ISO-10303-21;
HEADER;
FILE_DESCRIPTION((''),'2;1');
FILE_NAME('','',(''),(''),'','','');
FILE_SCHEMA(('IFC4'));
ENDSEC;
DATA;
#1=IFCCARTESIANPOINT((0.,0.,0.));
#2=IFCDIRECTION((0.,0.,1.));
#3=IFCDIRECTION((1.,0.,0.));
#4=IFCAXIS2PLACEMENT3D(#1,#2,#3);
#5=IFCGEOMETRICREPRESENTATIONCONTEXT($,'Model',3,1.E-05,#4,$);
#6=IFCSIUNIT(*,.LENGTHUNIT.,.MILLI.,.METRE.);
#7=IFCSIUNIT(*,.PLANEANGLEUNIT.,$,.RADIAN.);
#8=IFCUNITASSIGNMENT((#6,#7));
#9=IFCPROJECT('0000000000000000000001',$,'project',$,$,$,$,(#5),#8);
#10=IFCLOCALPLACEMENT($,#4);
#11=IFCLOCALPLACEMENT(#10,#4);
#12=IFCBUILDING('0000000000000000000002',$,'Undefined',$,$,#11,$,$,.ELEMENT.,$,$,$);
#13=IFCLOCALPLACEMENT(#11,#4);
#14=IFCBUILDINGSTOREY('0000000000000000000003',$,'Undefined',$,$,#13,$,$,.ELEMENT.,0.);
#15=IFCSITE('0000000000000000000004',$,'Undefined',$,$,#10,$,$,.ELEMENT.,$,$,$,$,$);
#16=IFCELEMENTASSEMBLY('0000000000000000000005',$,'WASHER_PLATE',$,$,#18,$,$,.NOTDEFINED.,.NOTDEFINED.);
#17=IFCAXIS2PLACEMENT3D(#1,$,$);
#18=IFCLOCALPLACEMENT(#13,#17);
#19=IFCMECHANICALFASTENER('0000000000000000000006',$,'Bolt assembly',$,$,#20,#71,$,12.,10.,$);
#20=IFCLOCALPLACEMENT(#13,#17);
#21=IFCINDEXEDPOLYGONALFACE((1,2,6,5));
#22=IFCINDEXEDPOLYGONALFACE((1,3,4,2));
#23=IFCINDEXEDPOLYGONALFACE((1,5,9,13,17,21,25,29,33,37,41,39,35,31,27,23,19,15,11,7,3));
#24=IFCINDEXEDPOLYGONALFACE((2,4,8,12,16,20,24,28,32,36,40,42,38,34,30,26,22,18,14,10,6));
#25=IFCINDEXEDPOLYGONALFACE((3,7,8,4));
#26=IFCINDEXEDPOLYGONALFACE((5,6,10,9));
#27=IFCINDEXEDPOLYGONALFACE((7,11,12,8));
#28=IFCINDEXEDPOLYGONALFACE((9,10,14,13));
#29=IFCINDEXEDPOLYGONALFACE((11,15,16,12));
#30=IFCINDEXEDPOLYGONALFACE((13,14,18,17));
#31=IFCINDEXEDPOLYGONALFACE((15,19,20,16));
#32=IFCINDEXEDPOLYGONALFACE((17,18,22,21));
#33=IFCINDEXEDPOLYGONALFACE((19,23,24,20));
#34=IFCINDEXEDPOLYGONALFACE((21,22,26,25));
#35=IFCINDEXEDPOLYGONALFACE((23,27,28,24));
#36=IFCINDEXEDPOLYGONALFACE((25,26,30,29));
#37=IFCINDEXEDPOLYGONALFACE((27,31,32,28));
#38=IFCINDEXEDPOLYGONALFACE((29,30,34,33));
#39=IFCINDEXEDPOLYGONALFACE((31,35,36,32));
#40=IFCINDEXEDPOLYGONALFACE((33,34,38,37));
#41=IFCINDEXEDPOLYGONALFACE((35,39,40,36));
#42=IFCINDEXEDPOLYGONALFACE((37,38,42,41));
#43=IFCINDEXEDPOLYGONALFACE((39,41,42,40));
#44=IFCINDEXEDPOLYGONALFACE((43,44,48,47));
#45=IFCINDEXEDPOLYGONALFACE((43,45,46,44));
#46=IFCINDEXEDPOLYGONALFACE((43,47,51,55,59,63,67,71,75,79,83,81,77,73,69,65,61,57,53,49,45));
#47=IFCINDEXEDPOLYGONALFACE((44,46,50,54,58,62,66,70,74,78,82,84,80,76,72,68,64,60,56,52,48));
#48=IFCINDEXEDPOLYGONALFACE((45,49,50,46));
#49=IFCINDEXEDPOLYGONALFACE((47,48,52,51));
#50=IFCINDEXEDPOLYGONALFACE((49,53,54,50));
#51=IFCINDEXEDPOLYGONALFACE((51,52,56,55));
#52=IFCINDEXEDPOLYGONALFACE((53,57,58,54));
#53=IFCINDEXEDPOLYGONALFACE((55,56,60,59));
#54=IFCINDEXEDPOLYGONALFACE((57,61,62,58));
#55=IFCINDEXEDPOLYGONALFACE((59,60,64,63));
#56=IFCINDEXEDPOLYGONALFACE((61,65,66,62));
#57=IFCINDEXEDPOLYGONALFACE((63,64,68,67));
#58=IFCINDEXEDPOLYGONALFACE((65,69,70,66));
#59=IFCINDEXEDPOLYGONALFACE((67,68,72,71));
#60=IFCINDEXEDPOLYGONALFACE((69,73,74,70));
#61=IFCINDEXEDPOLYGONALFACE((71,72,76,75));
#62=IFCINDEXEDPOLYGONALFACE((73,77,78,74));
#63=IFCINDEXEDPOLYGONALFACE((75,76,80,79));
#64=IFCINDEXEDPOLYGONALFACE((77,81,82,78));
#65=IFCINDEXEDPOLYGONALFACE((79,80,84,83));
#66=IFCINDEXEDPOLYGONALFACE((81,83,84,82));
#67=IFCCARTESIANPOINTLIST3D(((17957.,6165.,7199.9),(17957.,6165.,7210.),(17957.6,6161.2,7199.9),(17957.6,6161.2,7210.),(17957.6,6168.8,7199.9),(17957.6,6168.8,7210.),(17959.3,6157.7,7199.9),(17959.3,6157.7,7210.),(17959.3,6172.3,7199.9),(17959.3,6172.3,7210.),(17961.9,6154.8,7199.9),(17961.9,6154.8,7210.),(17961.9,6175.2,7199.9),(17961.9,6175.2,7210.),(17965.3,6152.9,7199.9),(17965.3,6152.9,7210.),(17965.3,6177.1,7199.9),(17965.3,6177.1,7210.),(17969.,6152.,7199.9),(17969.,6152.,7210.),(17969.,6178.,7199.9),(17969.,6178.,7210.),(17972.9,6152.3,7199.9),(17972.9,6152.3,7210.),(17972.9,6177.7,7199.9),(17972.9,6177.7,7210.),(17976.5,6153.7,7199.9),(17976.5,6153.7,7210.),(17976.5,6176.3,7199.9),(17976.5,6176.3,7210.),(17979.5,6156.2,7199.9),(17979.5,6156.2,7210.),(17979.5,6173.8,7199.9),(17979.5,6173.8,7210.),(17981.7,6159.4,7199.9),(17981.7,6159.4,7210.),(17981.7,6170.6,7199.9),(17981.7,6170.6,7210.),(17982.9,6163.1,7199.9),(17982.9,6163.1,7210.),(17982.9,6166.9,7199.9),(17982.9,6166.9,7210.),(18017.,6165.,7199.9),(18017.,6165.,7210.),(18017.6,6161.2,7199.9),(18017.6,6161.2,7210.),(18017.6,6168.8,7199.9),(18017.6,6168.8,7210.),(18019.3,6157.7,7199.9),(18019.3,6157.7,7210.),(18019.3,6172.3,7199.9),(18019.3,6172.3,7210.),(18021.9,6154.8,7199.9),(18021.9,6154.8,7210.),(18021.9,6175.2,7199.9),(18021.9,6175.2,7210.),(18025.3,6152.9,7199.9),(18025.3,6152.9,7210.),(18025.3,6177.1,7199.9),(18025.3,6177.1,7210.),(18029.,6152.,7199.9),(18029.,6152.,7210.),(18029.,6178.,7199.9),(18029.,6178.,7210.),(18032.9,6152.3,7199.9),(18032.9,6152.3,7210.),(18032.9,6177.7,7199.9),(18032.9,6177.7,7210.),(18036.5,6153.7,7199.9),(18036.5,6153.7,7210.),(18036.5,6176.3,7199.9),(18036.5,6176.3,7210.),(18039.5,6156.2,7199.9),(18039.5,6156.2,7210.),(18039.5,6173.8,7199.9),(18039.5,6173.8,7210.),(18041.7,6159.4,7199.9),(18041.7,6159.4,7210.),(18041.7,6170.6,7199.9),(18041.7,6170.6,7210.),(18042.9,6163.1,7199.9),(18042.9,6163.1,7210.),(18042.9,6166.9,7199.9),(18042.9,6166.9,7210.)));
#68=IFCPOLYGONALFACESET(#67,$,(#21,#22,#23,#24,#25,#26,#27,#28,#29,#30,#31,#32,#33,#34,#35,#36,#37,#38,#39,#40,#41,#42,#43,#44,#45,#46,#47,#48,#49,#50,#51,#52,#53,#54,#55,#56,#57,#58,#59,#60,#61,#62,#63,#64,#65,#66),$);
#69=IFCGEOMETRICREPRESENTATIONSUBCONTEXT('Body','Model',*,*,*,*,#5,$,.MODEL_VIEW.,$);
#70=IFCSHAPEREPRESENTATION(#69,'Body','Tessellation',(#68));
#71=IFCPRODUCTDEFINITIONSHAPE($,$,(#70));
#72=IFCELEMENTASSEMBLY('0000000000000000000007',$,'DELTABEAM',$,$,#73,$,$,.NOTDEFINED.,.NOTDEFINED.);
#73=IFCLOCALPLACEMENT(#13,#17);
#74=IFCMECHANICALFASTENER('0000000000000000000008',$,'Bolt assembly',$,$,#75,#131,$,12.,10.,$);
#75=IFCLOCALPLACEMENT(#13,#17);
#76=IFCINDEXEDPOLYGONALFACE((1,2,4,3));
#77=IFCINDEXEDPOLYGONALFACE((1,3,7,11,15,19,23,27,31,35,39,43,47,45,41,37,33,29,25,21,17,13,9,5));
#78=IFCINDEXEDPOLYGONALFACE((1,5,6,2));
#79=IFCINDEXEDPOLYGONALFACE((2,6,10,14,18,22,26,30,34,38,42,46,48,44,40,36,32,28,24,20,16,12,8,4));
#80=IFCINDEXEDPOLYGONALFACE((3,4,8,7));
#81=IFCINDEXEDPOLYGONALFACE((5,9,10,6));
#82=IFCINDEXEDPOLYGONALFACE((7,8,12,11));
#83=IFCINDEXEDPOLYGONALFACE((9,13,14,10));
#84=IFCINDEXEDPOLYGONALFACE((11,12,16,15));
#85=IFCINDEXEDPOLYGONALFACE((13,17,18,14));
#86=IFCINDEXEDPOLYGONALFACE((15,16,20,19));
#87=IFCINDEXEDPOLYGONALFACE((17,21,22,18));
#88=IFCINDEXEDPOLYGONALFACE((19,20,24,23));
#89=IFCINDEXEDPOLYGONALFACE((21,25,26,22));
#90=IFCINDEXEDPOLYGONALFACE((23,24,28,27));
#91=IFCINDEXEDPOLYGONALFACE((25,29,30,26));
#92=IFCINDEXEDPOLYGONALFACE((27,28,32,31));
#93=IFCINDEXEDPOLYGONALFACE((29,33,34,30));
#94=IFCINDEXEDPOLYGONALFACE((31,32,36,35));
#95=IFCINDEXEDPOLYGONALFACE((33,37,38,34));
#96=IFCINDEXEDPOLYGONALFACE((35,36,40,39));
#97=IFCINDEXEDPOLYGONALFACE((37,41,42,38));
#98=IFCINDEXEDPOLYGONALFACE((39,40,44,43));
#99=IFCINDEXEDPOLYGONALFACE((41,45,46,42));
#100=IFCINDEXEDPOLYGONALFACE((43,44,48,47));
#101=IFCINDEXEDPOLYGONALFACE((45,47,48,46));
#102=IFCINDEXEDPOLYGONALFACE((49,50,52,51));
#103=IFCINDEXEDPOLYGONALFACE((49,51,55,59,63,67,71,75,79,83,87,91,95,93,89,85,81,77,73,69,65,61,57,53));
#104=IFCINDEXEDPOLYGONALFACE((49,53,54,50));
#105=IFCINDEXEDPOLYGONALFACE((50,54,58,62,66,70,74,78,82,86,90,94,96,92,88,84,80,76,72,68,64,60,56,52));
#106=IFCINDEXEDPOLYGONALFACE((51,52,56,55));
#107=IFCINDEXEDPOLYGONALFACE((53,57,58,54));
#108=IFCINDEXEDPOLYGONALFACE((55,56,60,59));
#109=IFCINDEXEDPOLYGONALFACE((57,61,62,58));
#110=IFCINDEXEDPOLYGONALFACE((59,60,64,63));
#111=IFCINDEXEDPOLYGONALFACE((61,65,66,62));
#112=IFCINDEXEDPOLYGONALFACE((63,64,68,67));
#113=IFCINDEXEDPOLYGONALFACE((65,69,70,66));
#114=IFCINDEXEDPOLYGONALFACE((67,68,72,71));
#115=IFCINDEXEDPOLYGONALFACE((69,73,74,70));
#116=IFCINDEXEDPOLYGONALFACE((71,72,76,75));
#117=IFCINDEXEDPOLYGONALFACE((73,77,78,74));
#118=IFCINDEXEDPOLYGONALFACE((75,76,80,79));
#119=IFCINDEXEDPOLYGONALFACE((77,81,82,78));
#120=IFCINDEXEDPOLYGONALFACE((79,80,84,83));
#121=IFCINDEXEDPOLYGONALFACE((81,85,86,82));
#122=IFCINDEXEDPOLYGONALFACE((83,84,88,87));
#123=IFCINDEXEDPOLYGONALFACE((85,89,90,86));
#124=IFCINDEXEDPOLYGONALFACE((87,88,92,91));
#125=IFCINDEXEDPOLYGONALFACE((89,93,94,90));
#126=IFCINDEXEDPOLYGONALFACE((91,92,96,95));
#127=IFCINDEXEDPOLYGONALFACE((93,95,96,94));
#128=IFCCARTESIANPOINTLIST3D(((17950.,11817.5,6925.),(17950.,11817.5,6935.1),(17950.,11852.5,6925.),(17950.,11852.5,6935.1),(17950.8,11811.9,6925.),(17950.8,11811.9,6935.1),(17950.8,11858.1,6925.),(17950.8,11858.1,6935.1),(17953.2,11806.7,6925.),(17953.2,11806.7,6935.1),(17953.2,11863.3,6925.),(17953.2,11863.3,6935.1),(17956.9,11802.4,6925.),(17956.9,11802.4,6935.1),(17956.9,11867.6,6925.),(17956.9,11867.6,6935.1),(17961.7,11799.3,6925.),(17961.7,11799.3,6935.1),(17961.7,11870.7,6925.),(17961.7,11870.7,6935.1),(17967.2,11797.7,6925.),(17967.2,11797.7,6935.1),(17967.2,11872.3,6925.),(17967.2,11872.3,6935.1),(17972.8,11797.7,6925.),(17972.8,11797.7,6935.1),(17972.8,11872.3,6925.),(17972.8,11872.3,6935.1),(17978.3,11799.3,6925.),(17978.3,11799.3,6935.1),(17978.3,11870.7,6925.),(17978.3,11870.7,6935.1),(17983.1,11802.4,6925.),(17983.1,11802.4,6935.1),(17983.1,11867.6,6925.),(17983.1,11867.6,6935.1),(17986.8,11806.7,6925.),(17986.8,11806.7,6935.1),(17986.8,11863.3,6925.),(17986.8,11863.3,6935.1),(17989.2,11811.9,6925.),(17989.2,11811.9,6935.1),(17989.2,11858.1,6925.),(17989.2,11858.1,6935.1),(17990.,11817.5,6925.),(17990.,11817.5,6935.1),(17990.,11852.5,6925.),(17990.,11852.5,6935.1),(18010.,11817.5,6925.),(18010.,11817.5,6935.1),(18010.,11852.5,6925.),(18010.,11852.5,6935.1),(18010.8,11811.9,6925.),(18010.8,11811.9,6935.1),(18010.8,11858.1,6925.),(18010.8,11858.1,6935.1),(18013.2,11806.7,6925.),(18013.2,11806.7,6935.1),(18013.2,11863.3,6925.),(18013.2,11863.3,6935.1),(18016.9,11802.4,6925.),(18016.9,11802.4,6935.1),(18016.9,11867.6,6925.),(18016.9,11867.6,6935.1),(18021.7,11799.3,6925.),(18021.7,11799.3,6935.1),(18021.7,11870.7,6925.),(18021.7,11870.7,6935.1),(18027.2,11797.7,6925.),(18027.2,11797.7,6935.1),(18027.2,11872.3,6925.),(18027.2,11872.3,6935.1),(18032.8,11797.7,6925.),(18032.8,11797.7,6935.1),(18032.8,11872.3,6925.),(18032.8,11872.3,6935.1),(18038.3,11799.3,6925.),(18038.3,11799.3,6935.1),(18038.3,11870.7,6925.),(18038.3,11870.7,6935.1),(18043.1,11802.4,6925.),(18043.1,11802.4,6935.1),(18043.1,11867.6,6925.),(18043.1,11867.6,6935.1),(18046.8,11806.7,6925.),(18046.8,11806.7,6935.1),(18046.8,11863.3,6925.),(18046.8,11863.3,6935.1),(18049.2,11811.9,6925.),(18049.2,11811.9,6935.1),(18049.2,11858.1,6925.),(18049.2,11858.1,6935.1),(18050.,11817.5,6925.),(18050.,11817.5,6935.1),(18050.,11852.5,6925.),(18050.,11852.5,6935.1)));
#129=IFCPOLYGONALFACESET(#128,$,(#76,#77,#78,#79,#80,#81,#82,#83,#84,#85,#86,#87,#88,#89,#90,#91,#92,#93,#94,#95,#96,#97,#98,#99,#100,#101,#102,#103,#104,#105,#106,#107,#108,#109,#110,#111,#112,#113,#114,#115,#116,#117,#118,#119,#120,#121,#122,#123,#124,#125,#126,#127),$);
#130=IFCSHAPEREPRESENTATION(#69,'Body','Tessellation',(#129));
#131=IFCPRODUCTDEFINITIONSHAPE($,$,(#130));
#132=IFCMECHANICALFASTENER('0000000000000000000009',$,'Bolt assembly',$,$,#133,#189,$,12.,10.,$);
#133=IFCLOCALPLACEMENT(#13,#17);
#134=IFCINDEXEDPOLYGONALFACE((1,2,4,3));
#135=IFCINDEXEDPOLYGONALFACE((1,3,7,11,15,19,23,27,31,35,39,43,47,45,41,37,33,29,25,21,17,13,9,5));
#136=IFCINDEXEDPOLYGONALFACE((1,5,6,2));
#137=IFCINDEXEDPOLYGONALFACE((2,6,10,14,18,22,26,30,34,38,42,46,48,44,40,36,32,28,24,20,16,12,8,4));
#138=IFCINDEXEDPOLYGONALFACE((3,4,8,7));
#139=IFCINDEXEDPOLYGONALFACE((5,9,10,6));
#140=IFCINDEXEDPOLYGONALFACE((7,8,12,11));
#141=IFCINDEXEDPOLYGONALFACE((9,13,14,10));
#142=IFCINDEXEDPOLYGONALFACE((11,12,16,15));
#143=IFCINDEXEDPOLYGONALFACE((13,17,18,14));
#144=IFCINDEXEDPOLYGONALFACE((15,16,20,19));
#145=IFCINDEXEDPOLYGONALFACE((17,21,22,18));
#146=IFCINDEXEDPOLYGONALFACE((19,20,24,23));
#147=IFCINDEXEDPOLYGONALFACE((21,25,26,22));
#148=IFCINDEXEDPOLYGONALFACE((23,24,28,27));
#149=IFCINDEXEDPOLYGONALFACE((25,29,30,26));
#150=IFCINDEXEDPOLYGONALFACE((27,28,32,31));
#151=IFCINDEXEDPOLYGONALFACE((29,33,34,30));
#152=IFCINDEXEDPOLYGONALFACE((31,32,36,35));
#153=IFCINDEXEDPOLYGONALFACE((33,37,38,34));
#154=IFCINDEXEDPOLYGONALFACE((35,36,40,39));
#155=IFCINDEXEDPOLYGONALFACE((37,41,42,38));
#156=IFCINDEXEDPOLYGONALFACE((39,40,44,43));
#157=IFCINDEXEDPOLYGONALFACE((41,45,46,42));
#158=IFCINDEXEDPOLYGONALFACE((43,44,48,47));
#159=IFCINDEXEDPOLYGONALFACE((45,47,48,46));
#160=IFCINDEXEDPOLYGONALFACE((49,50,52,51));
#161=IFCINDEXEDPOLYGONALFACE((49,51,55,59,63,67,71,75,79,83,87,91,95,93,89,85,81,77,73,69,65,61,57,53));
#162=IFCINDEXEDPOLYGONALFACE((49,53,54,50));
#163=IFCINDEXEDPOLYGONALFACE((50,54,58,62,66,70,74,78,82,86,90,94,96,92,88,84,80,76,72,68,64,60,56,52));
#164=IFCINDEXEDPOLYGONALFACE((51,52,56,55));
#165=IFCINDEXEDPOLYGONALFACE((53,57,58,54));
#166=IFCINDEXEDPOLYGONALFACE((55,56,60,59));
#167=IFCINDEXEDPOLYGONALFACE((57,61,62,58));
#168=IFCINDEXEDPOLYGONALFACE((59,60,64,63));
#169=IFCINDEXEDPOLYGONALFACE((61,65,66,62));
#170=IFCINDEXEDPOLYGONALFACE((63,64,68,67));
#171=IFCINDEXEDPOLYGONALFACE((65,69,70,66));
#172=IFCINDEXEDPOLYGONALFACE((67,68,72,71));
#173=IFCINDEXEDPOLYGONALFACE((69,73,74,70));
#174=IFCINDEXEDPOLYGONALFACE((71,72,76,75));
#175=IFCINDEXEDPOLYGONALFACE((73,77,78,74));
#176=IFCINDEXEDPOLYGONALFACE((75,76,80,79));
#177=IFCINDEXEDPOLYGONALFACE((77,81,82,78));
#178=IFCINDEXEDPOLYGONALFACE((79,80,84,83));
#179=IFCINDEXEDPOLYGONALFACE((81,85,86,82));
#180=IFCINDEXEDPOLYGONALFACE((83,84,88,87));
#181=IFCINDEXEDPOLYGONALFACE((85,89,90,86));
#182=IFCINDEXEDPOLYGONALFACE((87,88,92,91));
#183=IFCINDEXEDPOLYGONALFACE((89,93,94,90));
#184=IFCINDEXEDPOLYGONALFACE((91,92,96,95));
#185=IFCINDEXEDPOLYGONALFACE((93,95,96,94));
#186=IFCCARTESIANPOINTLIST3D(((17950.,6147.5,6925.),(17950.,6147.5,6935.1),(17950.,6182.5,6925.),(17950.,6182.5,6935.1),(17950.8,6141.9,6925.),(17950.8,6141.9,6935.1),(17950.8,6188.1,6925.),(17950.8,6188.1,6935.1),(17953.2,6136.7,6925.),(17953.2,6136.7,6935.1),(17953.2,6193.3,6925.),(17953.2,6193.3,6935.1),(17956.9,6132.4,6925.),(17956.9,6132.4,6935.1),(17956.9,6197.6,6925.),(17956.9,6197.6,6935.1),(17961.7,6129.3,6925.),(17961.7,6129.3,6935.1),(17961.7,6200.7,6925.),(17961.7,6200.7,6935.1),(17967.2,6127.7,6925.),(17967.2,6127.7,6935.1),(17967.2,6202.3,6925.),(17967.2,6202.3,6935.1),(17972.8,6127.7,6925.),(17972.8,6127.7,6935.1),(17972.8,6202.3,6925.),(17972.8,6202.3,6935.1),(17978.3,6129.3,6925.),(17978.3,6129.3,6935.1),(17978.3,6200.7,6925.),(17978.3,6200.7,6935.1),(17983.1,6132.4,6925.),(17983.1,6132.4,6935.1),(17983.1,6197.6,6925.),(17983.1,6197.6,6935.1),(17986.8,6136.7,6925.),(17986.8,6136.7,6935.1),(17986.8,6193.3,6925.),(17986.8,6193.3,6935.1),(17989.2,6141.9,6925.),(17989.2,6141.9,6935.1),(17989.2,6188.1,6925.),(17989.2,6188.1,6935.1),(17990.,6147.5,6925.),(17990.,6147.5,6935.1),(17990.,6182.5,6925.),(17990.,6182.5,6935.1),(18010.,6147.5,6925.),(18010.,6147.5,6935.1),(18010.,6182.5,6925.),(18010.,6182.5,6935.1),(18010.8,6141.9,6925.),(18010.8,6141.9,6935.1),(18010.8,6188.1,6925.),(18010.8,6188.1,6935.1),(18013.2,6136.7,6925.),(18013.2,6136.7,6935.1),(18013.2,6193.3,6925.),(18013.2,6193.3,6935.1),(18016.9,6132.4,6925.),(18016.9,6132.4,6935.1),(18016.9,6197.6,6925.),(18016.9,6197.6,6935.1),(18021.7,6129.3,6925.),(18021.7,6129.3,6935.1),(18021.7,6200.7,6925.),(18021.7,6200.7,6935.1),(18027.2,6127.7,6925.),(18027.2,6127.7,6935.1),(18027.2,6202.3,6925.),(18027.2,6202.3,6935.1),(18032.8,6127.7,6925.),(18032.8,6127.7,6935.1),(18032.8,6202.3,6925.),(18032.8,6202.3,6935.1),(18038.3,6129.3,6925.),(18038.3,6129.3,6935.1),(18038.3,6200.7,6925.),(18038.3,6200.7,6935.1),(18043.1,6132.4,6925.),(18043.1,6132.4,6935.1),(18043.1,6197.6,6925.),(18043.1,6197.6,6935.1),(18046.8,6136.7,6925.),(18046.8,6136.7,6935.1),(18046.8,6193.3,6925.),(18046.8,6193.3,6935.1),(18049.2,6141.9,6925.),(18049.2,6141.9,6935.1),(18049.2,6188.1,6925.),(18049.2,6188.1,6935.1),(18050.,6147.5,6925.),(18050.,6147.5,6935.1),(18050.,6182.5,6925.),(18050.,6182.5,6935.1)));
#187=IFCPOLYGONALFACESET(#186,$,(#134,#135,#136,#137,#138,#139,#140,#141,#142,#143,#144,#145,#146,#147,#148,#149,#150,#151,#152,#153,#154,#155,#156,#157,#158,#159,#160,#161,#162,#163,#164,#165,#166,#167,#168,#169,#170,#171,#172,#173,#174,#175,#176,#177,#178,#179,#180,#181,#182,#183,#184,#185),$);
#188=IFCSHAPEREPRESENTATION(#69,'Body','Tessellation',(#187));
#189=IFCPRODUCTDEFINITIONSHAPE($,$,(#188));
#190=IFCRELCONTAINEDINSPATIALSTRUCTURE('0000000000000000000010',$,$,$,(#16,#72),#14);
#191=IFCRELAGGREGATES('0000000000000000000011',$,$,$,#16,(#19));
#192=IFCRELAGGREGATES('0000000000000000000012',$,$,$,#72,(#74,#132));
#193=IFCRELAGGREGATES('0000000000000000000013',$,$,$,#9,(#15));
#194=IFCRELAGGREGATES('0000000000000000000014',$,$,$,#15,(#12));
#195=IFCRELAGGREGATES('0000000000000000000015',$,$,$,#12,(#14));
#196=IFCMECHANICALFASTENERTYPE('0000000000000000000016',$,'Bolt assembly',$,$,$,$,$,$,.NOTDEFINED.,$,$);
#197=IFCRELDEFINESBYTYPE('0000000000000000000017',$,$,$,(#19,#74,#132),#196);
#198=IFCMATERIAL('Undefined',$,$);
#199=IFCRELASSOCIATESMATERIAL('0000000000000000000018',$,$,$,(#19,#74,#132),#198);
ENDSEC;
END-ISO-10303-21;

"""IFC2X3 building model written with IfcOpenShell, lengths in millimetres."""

from ifc_helpers import new_model, si_unit, frame, frame_2d, origin_with_axes, origin_2d_with_axis, place, context, subcontext, project, spatial, polyline, circle_curve, parameter, trimmed, segment, composite_curve, circle, outline, extrude, source, transform, mapped, material, type_object, element, aggregate, save


model = new_model("IFC2X3")

# Units and contexts
model_context = context("Model", 3, precision=1e-05, world=origin_with_axes())
body_context = subcontext(model_context, "Body", "Model", "MODEL_VIEW")
ifc_project = project(units=[si_unit("LENGTHUNIT", "METRE", prefix="MILLI"), si_unit("PLANEANGLEUNIT", "RADIAN")], contexts=[model_context])

# Site, building, storey
site_placement = place(None, origin_with_axes())
site = spatial("IfcSite", under=ifc_project, at=site_placement, Name="Undefined", CompositionType="ELEMENT")
building_placement = place(site_placement, origin_with_axes())
building = spatial("IfcBuilding", under=site, at=building_placement, Name="Undefined", CompositionType="ELEMENT")
storey_placement = place(building_placement, origin_with_axes())
storey = spatial("IfcBuildingStorey", under=building, at=storey_placement, Name="Undefined", CompositionType="ELEMENT", Elevation=0.0)

# Element assembly
assembly_1_placement = place(storey_placement, origin_with_axes())
assembly_1 = element("IfcElementAssembly", 1, at=assembly_1_placement, inside=storey, Name="WASHER_PLATE", AssemblyPlace="NOTDEFINED", PredefinedType="NOTDEFINED")

# Shared definitions
ifc_material_1 = material(Name="Undefined")
mechanical_fastener_type = type_object("IfcMechanicalFastenerType", Name="Bolt assembly")
shared_shape_1 = source(origin_with_axes(), body_context, "Body", "SweptSolid", [
    extrude(circle(Radius=13.0, at=origin_2d_with_axis()), frame((0.0, 5.0, 0.0), z_axis=(0.0, 1.0, 0.0), x_axis=(1.0, 0.0, 0.0)), (0.0, 0.0, 1.0), 10.1),
])

# Mechanical fastener
mechanical_fastener_1_placement = place(assembly_1_placement, frame((18030.0, 6165.0, 7215.0), z_axis=(0.0, -1.0, 0.0), x_axis=(-1.0, 0.0, 0.0)))
mechanical_fastener_1 = element("IfcMechanicalFastener", 2, at=mechanical_fastener_1_placement, type_object=mechanical_fastener_type, material=ifc_material_1, Name="Bolt assembly", NominalDiameter=12.0, NominalLength=10.0, context=body_context, shape_type="MappedRepresentation", body=[
    mapped(shared_shape_1, transform((0.0, 0.0, 0.0))),
    mapped(shared_shape_1, transform((60.0, 0.0, 0.0))),
])
aggregate(assembly_1, [mechanical_fastener_1])

# Element assembly, mechanical fastener
assembly_2_placement = place(storey_placement, origin_with_axes())
assembly_2 = element("IfcElementAssembly", 3, at=assembly_2_placement, inside=storey, Name="DELTABEAM", AssemblyPlace="NOTDEFINED", PredefinedType="NOTDEFINED")
shared_shape_2 = source(origin_with_axes(), body_context, "Body", "SweptSolid", [
    extrude(outline(composite_curve([segment(polyline([(20.0, 17.5), (20.0, -17.5)]), True, "CONTINUOUS"), segment(trimmed(circle_curve(frame_2d((0.0, -17.5), x_axis=(1.0, 0.0)), 20.0), [parameter(0.0)], [parameter(3.141593)], False, "PARAMETER"), True, "CONTINUOUS"), segment(polyline([(-20.0, -17.5), (-20.0, 17.5)]), True, "CONTINUOUS"), segment(trimmed(circle_curve(frame_2d((0.0, 17.5), x_axis=(-1.0, 0.0)), 20.0), [parameter(0.0)], [parameter(3.141593)], False, "PARAMETER"), True, "DISCONTINUOUS")], self_intersect=False)), frame((0.0, -15.0, 0.0), z_axis=(0.0, 1.0, 0.0), x_axis=(1.0, 0.0, 0.0)), (0.0, 0.0, 1.0), 10.1),
])
mechanical_fastener_2_placement = place(assembly_2_placement, frame((18030.0, 11835.0, 6940.0), z_axis=(0.0, 1.0, 0.0), x_axis=(-1.0, 0.0, 0.0)))
mechanical_fastener_2 = element("IfcMechanicalFastener", 4, at=mechanical_fastener_2_placement, type_object=mechanical_fastener_type, material=ifc_material_1, Name="Bolt assembly", NominalDiameter=12.0, NominalLength=10.0, context=body_context, shape_type="MappedRepresentation", body=[
    mapped(shared_shape_2, transform((0.0, 0.0, 0.0))),
    mapped(shared_shape_2, transform((60.0, 0.0, 0.0))),
])

# Mechanical fastener
shared_shape_3 = source(origin_with_axes(), body_context, "Body", "SweptSolid", [
    extrude(outline(composite_curve([segment(polyline([(20.0, 17.5), (20.0, -17.5)]), True, "CONTINUOUS"), segment(trimmed(circle_curve(frame_2d((0.0, -17.5), x_axis=(1.0, 0.0)), 20.0), [parameter(0.0)], [parameter(3.141593)], False, "PARAMETER"), True, "CONTINUOUS"), segment(polyline([(-20.0, -17.5), (-20.0, 17.5)]), True, "CONTINUOUS"), segment(trimmed(circle_curve(frame_2d((0.0, 17.5), x_axis=(-1.0, 0.0)), 20.0), [parameter(0.0)], [parameter(3.141593)], False, "PARAMETER"), True, "DISCONTINUOUS")], self_intersect=False)), frame((0.0, -15.0, 0.0), z_axis=(0.0, 1.0, 0.0), x_axis=(1.0, 0.0, 0.0)), (0.0, 0.0, 1.0), 10.1),
])
mechanical_fastener_3_placement = place(assembly_2_placement, frame((18030.0, 6165.0, 6940.0), z_axis=(0.0, 1.0, 0.0), x_axis=(-1.0, 0.0, 0.0)))
mechanical_fastener_3 = element("IfcMechanicalFastener", 5, at=mechanical_fastener_3_placement, type_object=mechanical_fastener_type, material=ifc_material_1, Name="Bolt assembly", NominalDiameter=12.0, NominalLength=10.0, context=body_context, shape_type="MappedRepresentation", body=[
    mapped(shared_shape_3, transform((0.0, 0.0, 0.0))),
    mapped(shared_shape_3, transform((60.0, 0.0, 0.0))),
])
aggregate(assembly_2, [mechanical_fastener_2, mechanical_fastener_3])

save(model, "model.ifc")
